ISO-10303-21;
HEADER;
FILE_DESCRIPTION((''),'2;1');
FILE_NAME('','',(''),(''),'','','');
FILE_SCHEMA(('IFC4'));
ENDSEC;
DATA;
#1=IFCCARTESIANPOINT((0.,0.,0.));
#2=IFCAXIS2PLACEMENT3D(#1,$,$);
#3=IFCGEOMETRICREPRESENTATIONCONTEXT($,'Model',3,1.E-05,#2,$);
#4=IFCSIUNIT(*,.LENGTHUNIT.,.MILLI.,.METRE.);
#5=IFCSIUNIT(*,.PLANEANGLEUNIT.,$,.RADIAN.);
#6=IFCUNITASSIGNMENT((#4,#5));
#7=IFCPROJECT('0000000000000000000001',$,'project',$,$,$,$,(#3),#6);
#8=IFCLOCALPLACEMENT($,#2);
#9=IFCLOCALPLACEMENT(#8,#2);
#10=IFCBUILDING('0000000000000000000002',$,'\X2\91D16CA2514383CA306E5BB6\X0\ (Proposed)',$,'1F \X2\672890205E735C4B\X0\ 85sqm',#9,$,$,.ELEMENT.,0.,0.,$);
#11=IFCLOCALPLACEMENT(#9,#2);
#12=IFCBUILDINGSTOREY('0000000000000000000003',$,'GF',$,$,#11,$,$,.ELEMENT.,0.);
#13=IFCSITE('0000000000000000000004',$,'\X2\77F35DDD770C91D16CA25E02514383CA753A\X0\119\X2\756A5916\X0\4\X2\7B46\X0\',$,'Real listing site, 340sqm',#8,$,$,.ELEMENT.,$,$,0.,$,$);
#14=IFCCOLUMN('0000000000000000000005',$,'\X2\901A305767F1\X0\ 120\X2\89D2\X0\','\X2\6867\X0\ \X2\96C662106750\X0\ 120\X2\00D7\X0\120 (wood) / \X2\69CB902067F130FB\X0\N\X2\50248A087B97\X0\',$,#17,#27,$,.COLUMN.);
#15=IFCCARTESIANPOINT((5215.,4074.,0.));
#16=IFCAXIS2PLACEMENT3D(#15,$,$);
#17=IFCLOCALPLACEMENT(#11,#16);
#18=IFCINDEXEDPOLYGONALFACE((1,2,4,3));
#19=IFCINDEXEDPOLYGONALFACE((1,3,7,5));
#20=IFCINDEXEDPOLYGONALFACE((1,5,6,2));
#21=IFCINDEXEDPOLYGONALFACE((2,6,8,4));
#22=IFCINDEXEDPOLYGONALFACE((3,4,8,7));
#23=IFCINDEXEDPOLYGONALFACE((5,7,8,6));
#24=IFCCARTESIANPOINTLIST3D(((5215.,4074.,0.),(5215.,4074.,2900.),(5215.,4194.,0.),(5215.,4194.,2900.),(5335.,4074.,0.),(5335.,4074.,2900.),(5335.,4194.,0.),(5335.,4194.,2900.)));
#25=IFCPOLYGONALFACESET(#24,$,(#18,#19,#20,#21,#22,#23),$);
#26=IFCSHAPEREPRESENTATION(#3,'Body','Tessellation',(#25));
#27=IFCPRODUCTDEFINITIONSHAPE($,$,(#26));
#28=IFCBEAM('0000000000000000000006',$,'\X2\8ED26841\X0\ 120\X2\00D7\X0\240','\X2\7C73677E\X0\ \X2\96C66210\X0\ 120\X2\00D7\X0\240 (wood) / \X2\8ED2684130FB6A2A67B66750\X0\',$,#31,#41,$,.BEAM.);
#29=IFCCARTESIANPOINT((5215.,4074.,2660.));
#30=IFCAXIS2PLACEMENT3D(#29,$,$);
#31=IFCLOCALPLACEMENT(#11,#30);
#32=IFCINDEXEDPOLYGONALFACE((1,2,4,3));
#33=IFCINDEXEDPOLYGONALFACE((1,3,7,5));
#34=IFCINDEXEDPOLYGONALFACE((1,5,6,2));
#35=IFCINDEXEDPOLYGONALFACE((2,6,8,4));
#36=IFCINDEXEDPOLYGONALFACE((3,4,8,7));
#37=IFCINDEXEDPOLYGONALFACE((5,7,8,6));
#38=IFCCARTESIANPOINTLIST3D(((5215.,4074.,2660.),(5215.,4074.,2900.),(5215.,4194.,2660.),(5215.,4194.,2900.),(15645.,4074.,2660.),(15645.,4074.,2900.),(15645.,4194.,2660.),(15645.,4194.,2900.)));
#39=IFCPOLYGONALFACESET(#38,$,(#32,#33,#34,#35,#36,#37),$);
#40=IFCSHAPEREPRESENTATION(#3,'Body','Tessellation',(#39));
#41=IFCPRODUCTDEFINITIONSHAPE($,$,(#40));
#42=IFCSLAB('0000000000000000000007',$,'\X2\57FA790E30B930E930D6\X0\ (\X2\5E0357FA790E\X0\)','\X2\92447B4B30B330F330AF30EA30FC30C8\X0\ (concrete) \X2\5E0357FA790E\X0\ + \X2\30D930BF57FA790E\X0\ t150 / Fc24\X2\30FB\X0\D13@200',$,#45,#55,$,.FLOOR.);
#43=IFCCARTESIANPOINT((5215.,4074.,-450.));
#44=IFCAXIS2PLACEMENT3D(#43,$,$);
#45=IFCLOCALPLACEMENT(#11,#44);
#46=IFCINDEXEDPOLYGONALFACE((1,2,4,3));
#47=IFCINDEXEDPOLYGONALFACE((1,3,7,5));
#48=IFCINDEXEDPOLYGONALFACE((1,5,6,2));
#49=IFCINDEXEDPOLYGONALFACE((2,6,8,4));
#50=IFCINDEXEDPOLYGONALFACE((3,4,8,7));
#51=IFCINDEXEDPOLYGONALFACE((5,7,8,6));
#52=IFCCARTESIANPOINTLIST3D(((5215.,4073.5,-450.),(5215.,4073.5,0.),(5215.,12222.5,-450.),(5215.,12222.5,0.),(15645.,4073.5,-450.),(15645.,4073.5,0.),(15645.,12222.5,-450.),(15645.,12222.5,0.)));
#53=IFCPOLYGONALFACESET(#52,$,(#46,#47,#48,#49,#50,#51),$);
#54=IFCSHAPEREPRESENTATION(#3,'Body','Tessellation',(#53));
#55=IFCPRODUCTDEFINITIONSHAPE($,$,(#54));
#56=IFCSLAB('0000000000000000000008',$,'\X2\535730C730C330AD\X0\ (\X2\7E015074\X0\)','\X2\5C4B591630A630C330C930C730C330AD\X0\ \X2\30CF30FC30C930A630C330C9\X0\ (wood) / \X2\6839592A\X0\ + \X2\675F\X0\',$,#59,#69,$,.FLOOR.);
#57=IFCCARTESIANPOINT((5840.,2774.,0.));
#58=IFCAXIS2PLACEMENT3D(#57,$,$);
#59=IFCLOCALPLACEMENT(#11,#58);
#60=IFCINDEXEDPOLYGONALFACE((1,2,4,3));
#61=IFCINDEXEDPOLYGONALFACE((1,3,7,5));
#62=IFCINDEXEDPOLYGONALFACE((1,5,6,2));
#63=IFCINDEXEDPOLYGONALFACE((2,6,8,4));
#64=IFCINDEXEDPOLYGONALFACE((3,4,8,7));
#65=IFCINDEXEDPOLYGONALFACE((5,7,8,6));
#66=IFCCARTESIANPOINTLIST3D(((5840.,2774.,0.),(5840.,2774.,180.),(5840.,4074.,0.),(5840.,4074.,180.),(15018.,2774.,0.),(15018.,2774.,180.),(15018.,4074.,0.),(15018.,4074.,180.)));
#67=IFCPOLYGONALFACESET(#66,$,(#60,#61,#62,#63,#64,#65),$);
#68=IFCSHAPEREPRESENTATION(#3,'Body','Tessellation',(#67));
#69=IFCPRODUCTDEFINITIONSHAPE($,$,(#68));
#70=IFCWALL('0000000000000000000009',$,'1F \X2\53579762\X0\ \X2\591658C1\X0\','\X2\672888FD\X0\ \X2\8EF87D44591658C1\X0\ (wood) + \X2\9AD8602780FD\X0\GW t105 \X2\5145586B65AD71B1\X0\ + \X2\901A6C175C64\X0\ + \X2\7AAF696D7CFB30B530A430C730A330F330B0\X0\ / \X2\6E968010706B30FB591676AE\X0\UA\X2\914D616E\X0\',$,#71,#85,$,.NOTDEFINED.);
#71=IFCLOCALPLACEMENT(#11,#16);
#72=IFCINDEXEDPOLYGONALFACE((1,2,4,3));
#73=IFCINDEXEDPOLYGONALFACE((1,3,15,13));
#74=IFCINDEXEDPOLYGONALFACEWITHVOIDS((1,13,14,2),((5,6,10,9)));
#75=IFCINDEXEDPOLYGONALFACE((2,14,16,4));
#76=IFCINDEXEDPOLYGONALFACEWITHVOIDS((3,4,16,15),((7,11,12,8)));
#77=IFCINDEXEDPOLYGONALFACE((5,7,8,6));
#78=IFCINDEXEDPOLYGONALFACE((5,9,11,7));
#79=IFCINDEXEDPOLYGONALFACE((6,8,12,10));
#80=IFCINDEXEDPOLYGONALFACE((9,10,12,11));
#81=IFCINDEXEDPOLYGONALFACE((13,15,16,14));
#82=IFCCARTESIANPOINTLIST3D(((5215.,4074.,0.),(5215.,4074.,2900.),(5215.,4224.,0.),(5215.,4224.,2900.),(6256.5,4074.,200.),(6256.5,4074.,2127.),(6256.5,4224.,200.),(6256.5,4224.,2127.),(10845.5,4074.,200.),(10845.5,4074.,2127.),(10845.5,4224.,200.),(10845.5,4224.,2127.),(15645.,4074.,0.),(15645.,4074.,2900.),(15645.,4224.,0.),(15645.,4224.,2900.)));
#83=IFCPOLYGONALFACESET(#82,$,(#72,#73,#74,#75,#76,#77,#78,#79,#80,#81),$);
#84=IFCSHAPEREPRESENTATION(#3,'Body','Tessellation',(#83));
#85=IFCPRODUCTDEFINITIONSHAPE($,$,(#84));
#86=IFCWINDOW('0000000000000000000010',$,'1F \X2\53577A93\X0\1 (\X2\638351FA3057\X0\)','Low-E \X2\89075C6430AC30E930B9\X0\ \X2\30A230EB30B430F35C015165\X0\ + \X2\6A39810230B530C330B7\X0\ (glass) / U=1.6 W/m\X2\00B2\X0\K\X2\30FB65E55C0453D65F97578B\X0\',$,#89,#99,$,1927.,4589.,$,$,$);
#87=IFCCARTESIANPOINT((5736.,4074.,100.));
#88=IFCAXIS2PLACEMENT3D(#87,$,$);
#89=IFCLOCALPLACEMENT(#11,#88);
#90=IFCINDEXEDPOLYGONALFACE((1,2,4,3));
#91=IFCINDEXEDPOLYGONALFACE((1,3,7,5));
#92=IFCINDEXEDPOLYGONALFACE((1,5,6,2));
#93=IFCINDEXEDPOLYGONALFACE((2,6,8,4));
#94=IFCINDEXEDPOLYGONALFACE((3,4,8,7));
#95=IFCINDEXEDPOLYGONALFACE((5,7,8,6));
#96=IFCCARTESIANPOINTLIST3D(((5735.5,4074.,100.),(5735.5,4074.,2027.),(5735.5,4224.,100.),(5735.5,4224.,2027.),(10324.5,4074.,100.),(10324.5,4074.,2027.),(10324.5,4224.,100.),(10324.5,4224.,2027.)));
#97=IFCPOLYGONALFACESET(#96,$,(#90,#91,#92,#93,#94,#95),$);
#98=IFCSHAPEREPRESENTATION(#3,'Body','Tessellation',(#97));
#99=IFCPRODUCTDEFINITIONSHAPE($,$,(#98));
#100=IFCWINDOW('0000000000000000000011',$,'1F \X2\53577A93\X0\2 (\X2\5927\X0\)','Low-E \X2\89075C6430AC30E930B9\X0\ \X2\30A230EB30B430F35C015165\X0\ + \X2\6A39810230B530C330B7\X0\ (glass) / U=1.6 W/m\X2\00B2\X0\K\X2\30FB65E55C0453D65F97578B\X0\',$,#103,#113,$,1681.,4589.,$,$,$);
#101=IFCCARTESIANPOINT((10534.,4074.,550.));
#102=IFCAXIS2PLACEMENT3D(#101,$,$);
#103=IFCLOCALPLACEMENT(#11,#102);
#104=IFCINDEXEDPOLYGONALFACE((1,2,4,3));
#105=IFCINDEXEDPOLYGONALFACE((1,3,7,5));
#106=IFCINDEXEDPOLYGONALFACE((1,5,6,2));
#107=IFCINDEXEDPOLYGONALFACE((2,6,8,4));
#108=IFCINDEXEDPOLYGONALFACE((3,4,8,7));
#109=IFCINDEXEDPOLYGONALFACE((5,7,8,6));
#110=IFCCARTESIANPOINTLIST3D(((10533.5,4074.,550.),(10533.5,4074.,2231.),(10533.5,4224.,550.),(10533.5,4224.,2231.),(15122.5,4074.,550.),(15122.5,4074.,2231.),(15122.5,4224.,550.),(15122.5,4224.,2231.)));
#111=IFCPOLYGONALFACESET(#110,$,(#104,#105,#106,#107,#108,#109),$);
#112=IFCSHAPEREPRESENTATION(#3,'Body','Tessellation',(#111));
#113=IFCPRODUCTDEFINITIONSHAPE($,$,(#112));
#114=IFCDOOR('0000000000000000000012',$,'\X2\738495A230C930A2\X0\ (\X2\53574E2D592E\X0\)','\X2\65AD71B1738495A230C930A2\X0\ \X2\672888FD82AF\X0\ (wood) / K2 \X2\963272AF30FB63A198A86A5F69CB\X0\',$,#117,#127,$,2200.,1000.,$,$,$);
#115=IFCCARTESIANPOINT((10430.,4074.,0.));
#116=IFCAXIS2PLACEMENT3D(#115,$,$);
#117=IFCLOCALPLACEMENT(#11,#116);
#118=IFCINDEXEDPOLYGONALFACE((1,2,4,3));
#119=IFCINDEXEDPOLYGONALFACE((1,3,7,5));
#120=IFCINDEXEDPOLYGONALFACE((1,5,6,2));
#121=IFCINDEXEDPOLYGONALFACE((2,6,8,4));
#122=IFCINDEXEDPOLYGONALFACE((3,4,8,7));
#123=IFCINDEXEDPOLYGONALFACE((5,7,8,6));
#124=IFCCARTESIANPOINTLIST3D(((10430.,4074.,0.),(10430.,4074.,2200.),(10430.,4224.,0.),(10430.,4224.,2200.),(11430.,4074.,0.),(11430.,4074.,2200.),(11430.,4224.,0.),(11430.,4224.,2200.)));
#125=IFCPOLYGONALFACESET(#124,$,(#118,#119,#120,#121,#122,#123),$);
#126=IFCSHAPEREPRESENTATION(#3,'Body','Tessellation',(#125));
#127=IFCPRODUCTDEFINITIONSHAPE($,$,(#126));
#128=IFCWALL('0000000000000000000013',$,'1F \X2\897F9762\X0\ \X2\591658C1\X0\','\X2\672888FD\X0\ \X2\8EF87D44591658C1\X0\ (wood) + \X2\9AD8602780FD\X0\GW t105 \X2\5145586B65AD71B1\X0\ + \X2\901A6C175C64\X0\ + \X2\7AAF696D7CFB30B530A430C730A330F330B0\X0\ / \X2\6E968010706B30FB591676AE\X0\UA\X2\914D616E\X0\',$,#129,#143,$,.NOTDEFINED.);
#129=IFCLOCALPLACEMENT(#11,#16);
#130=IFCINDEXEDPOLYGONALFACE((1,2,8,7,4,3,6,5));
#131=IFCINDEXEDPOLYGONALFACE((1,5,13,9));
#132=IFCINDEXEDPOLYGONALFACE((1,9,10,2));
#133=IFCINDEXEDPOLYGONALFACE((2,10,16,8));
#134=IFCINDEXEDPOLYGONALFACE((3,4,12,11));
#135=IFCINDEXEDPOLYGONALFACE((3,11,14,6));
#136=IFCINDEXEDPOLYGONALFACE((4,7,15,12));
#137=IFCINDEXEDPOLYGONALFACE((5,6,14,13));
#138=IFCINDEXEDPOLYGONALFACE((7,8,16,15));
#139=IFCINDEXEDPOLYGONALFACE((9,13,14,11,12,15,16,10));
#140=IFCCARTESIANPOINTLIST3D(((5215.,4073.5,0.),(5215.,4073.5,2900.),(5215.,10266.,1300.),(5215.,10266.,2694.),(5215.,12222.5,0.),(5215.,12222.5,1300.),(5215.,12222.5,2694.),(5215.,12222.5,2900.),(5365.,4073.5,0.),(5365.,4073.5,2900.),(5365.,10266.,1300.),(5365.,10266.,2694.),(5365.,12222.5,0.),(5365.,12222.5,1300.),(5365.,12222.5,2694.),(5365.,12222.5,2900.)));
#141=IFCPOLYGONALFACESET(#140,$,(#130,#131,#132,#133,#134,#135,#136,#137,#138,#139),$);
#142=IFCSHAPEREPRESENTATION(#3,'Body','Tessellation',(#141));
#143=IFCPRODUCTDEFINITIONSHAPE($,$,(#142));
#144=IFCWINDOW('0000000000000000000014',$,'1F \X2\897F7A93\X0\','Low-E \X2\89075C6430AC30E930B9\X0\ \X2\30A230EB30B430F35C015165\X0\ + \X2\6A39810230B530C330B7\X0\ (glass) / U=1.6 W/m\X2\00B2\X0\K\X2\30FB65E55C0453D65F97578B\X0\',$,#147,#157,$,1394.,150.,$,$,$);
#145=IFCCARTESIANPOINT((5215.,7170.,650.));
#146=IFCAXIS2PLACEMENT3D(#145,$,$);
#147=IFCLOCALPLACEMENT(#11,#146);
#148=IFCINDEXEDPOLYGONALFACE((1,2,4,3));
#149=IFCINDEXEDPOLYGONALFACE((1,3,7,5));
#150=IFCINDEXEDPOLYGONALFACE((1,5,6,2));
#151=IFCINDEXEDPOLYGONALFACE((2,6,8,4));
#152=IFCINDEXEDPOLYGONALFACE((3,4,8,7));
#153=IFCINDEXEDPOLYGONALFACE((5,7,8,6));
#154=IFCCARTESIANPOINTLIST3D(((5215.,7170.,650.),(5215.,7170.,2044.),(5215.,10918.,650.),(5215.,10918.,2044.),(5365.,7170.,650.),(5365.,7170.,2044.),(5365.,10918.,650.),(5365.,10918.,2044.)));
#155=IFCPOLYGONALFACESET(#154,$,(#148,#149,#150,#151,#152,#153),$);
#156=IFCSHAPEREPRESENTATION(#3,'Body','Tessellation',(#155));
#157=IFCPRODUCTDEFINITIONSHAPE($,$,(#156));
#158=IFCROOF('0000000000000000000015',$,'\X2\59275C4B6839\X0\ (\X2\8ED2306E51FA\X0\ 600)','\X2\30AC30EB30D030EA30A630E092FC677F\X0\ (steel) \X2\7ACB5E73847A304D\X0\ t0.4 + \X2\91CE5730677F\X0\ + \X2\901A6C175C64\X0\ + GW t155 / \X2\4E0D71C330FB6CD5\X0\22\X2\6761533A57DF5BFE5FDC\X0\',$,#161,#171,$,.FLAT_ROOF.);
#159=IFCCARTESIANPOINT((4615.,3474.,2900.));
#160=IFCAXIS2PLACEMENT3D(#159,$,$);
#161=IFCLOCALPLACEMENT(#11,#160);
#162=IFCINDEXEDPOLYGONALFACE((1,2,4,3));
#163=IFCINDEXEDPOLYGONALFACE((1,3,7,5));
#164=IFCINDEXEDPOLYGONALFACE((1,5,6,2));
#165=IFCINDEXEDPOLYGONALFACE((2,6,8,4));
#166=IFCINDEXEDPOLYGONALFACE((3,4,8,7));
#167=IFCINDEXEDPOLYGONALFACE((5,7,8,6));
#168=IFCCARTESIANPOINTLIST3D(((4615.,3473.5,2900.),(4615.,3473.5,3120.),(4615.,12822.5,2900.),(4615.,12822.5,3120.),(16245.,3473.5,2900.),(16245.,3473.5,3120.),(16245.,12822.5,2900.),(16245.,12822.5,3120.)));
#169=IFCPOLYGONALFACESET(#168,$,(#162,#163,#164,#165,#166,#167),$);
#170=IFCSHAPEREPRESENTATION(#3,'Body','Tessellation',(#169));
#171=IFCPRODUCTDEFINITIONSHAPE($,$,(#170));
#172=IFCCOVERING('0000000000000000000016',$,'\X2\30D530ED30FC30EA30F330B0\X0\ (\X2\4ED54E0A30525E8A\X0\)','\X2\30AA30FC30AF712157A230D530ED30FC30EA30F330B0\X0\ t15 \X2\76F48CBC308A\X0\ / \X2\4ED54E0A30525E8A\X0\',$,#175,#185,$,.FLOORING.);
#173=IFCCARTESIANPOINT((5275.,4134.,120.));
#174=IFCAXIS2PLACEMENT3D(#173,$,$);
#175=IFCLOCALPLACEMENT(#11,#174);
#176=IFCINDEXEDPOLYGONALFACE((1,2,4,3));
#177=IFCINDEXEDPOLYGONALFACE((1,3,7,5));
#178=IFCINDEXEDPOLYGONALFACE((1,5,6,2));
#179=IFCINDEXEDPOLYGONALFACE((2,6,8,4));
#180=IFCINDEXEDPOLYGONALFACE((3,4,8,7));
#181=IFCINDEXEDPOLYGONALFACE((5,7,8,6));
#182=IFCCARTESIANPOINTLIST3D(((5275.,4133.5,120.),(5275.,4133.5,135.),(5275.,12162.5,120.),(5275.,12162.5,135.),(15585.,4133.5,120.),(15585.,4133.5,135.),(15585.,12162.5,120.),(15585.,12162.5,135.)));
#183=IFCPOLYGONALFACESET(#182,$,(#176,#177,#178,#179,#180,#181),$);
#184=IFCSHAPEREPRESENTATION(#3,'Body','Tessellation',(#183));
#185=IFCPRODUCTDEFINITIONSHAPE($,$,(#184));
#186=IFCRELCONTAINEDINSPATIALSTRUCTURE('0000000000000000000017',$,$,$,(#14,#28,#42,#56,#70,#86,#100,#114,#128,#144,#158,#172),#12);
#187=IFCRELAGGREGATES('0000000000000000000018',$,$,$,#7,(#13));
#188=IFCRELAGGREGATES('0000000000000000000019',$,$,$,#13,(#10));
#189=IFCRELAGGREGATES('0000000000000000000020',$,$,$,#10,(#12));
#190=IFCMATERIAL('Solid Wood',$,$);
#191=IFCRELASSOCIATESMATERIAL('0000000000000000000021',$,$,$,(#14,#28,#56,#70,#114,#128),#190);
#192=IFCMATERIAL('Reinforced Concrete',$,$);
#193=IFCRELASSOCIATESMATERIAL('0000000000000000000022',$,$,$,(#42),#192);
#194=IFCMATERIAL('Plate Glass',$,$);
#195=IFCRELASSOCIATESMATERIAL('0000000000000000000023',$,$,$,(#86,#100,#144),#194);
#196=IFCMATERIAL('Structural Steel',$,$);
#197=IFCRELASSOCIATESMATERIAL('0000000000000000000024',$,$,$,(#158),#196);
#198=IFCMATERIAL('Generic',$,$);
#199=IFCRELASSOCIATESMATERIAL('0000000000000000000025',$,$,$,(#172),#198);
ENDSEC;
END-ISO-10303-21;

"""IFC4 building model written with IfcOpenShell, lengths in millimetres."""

from ifc_helpers import new_model, si_unit, frame, frame_2d, origin, place, context, project, spatial, rectangle, extrude, material, element, fill, save


model = new_model("IFC4")

# Units and contexts
model_context = context("Model", 3, precision=1e-05, world=origin())
ifc_project = project(units=[si_unit("LENGTHUNIT", "METRE", prefix="MILLI"), si_unit("PLANEANGLEUNIT", "RADIAN")], contexts=[model_context])

# Site, building, storey
site_placement = place(None, origin())
site = spatial("IfcSite", under=ifc_project, at=site_placement, Name="石川県金沢市元菊町119番外4筆", ObjectType="Real listing site, 340sqm", CompositionType="ELEMENT", RefElevation=0.0)
building_placement = place(site_placement, origin())
building = spatial("IfcBuilding", under=site, at=building_placement, Name="金沢元菊の家 (Proposed)", ObjectType="1F 木造平屋 85sqm", CompositionType="ELEMENT", ElevationOfRefHeight=0.0, ElevationOfTerrain=0.0)
storey_placement = place(building_placement, origin())
storey = spatial("IfcBuildingStorey", under=building, at=storey_placement, Name="GF", CompositionType="ELEMENT", Elevation=0.0)

# Column
ifc_material_1 = material(Name="Solid Wood")
column_placement = place(storey_placement, frame((5215.0, 4074.0, 0.0)))
element("IfcColumn", 1, at=column_placement, inside=storey, material=ifc_material_1, Name="通し柱 120角", Description="桧 集成材 120×120 (wood) / 構造柱・N値計算", PredefinedType="COLUMN", context=model_context, shape_type="SweptSolid", body=[
    extrude(rectangle(XDim=120.0, YDim=120.0, at=frame_2d((60.0, 60.0))), frame((5215.0, 4074.0, 0.0)), (0.0, 0.0, 1.0), 2900.0),
])

# Beam
beam_1_placement = place(storey_placement, frame((5215.0, 4074.0, 2660.0)))
element("IfcBeam", 2, at=beam_1_placement, inside=storey, material=ifc_material_1, Name="軒桁 120×240", Description="米松 集成 120×240 (wood) / 軒桁・横架材", PredefinedType="BEAM", context=model_context, shape_type="SweptSolid", body=[
    extrude(rectangle(XDim=10430.0, YDim=120.0, at=frame_2d((5215.0, 60.0))), frame((5215.0, 4074.0, 2660.0)), (0.0, 0.0, 1.0), 240.0),
])

# Slabs
ifc_material_2 = material(Name="Reinforced Concrete")
slab_1_placement = place(storey_placement, frame((5215.0, 4074.0, -450.0)))
element("IfcSlab", 3, at=slab_1_placement, inside=storey, material=ifc_material_2, Name="基礎スラブ (布基礎)", Description="鉄筋コンクリート (concrete) 布基礎 + ベタ基礎 t150 / Fc24・D13@200", PredefinedType="FLOOR", context=model_context, shape_type="SweptSolid", body=[
    extrude(rectangle(XDim=10430.0, YDim=8149.0, at=frame_2d((5215.0, 4074.0))), frame((5215.0, 4074.0, -450.0)), (0.0, 0.0, 1.0), 450.0),
])
slab_2_placement = place(storey_placement, frame((5840.0, 2774.0, 0.0)))
element("IfcSlab", 4, at=slab_2_placement, inside=storey, material=ifc_material_1, Name="南デッキ (縁側)", Description="屋外ウッドデッキ ハードウッド (wood) / 根太 + 束", PredefinedType="FLOOR", context=model_context, shape_type="SweptSolid", body=[
    extrude(rectangle(XDim=9178.0, YDim=1300.0, at=frame_2d((4589.0, 650.0))), frame((5840.0, 2774.0, 0.0)), (0.0, 0.0, 1.0), 180.0),
])

# Wall, openings, windows, door
wall_1_placement = place(storey_placement, frame((5215.0, 4074.0, 0.0)))
wall_1 = element("IfcWall", 5, at=wall_1_placement, inside=storey, material=ifc_material_1, Name="1F 南面 外壁", Description="木製 軸組外壁 (wood) + 高性能GW t105 充填断熱 + 通気層 + 窯業系サイディング / 準耐火・外皮UA配慮", PredefinedType="NOTDEFINED", context=model_context, shape_type="SweptSolid", body=[
    extrude(rectangle(XDim=10430.0, YDim=150.0, at=frame_2d((5215.0, 75.0))), frame((5215.0, 4074.0, 0.0)), (0.0, 0.0, 1.0), 2900.0),
])
opening_1_placement = place(storey_placement, frame((5736.0, 4074.0, 100.0)))
opening_1 = element("IfcOpeningElement", 6, at=opening_1_placement, cuts=wall_1, PredefinedType="NOTDEFINED", context=model_context, shape_type="SweptSolid", body=[
    extrude(rectangle(XDim=4589.0, YDim=150.0, at=frame_2d((2294.0, 75.0))), frame((5736.0, 4074.0, 100.0)), (0.0, 0.0, 1.0), 1927.0),
])
opening_2_placement = place(storey_placement, frame((10534.0, 4074.0, 550.0)))
opening_2 = element("IfcOpeningElement", 7, at=opening_2_placement, cuts=wall_1, PredefinedType="NOTDEFINED", context=model_context, shape_type="SweptSolid", body=[
    extrude(rectangle(XDim=4589.0, YDim=150.0, at=frame_2d((2294.0, 75.0))), frame((10534.0, 4074.0, 550.0)), (0.0, 0.0, 1.0), 1681.0),
])
opening_3_placement = place(storey_placement, frame((10430.0, 4074.0, 0.0)))
opening_3 = element("IfcOpeningElement", 8, at=opening_3_placement, cuts=wall_1, PredefinedType="NOTDEFINED", context=model_context, shape_type="SweptSolid", body=[
    extrude(rectangle(XDim=1000.0, YDim=150.0, at=frame_2d((500.0, 75.0))), frame((10430.0, 4074.0, 0.0)), (0.0, 0.0, 1.0), 2200.0),
])
ifc_material_3 = material(Name="Plate Glass")
window_1_placement = place(storey_placement, frame((5736.0, 4074.0, 100.0)))
window_1 = element("IfcWindow", 9, at=window_1_placement, inside=storey, material=ifc_material_3, Name="1F 南窓1 (掃出し)", Description="Low-E 複層ガラス アルゴン封入 + 樹脂サッシ (glass) / U=1.6 W/m²K・日射取得型", OverallHeight=1927.0, OverallWidth=4589.0, context=model_context, shape_type="SweptSolid", body=[
    extrude(rectangle(XDim=4589.0, YDim=150.0, at=frame_2d((2294.0, 75.0))), frame((5736.0, 4074.0, 100.0)), (0.0, 0.0, 1.0), 1927.0),
])
fill(opening_1, window_1)
window_2_placement = place(storey_placement, frame((10534.0, 4074.0, 550.0)))
window_2 = element("IfcWindow", 10, at=window_2_placement, inside=storey, material=ifc_material_3, Name="1F 南窓2 (大)", Description="Low-E 複層ガラス アルゴン封入 + 樹脂サッシ (glass) / U=1.6 W/m²K・日射取得型", OverallHeight=1681.0, OverallWidth=4589.0, context=model_context, shape_type="SweptSolid", body=[
    extrude(rectangle(XDim=4589.0, YDim=150.0, at=frame_2d((2294.0, 75.0))), frame((10534.0, 4074.0, 550.0)), (0.0, 0.0, 1.0), 1681.0),
])
fill(opening_2, window_2)
door_placement = place(storey_placement, frame((10430.0, 4074.0, 0.0)))
door = element("IfcDoor", 11, at=door_placement, inside=storey, material=ifc_material_1, Name="玄関ドア (南中央)", Description="断熱玄関ドア 木製芯 (wood) / K2 防犯・採風機構", OverallHeight=2200.0, OverallWidth=1000.0, context=model_context, shape_type="SweptSolid", body=[
    extrude(rectangle(XDim=1000.0, YDim=150.0, at=frame_2d((500.0, 75.0))), frame((10430.0, 4074.0, 0.0)), (0.0, 0.0, 1.0), 2200.0),
])
fill(opening_3, door)

# Wall, opening, window
wall_2_placement = place(storey_placement, frame((5215.0, 4074.0, 0.0)))
wall_2 = element("IfcWall", 12, at=wall_2_placement, inside=storey, material=ifc_material_1, Name="1F 西面 外壁", Description="木製 軸組外壁 (wood) + 高性能GW t105 充填断熱 + 通気層 + 窯業系サイディング / 準耐火・外皮UA配慮", PredefinedType="NOTDEFINED", context=model_context, shape_type="SweptSolid", body=[
    extrude(rectangle(XDim=150.0, YDim=8149.0, at=frame_2d((75.0, 4074.0))), frame((5215.0, 4074.0, 0.0)), (0.0, 0.0, 1.0), 2900.0),
])
opening_4_placement = place(storey_placement, frame((5215.0, 7170.0, 650.0)))
opening_4 = element("IfcOpeningElement", 13, at=opening_4_placement, cuts=wall_2, PredefinedType="NOTDEFINED", context=model_context, shape_type="SweptSolid", body=[
    extrude(rectangle(XDim=150.0, YDim=3748.0, at=frame_2d((75.0, 1874.0))), frame((5215.0, 7170.0, 650.0)), (0.0, 0.0, 1.0), 1394.0),
])
window_3_placement = place(storey_placement, frame((5215.0, 7170.0, 650.0)))
window_3 = element("IfcWindow", 14, at=window_3_placement, inside=storey, material=ifc_material_3, Name="1F 西窓", Description="Low-E 複層ガラス アルゴン封入 + 樹脂サッシ (glass) / U=1.6 W/m²K・日射取得型", OverallHeight=1394.0, OverallWidth=150.0, context=model_context, shape_type="SweptSolid", body=[
    extrude(rectangle(XDim=150.0, YDim=3748.0, at=frame_2d((75.0, 1874.0))), frame((5215.0, 7170.0, 650.0)), (0.0, 0.0, 1.0), 1394.0),
])
fill(opening_4, window_3)

# Roof
ifc_material_4 = material(Name="Structural Steel")
roof_placement = place(storey_placement, frame((4615.0, 3474.0, 2900.0)))
element("IfcRoof", 15, at=roof_placement, inside=storey, material=ifc_material_4, Name="大屋根 (軒の出 600)", Description="ガルバリウム鋼板 (steel) 立平葺き t0.4 + 野地板 + 通気層 + GW t155 / 不燃・法22条区域対応", PredefinedType="FLAT_ROOF", context=model_context, shape_type="SweptSolid", body=[
    extrude(rectangle(XDim=11630.0, YDim=9349.0, at=frame_2d((5815.0, 4674.0))), frame((4615.0, 3474.0, 2900.0)), (0.0, 0.0, 1.0), 220.0),
])

# Covering
ifc_material_5 = material(Name="Generic")
covering_1_placement = place(storey_placement, frame((5275.0, 4134.0, 120.0)))
element("IfcCovering", 16, at=covering_1_placement, inside=storey, material=ifc_material_5, Name="フローリング (仕上げ床)", Description="オーク無垢フローリング t15 直貼り / 仕上げ床", PredefinedType="FLOORING", context=model_context, shape_type="SweptSolid", body=[
    extrude(rectangle(XDim=10310.0, YDim=8029.0, at=frame_2d((5155.0, 4014.0))), frame((5275.0, 4134.0, 120.0)), (0.0, 0.0, 1.0), 15.0),
])

save(model, "model.ifc")
